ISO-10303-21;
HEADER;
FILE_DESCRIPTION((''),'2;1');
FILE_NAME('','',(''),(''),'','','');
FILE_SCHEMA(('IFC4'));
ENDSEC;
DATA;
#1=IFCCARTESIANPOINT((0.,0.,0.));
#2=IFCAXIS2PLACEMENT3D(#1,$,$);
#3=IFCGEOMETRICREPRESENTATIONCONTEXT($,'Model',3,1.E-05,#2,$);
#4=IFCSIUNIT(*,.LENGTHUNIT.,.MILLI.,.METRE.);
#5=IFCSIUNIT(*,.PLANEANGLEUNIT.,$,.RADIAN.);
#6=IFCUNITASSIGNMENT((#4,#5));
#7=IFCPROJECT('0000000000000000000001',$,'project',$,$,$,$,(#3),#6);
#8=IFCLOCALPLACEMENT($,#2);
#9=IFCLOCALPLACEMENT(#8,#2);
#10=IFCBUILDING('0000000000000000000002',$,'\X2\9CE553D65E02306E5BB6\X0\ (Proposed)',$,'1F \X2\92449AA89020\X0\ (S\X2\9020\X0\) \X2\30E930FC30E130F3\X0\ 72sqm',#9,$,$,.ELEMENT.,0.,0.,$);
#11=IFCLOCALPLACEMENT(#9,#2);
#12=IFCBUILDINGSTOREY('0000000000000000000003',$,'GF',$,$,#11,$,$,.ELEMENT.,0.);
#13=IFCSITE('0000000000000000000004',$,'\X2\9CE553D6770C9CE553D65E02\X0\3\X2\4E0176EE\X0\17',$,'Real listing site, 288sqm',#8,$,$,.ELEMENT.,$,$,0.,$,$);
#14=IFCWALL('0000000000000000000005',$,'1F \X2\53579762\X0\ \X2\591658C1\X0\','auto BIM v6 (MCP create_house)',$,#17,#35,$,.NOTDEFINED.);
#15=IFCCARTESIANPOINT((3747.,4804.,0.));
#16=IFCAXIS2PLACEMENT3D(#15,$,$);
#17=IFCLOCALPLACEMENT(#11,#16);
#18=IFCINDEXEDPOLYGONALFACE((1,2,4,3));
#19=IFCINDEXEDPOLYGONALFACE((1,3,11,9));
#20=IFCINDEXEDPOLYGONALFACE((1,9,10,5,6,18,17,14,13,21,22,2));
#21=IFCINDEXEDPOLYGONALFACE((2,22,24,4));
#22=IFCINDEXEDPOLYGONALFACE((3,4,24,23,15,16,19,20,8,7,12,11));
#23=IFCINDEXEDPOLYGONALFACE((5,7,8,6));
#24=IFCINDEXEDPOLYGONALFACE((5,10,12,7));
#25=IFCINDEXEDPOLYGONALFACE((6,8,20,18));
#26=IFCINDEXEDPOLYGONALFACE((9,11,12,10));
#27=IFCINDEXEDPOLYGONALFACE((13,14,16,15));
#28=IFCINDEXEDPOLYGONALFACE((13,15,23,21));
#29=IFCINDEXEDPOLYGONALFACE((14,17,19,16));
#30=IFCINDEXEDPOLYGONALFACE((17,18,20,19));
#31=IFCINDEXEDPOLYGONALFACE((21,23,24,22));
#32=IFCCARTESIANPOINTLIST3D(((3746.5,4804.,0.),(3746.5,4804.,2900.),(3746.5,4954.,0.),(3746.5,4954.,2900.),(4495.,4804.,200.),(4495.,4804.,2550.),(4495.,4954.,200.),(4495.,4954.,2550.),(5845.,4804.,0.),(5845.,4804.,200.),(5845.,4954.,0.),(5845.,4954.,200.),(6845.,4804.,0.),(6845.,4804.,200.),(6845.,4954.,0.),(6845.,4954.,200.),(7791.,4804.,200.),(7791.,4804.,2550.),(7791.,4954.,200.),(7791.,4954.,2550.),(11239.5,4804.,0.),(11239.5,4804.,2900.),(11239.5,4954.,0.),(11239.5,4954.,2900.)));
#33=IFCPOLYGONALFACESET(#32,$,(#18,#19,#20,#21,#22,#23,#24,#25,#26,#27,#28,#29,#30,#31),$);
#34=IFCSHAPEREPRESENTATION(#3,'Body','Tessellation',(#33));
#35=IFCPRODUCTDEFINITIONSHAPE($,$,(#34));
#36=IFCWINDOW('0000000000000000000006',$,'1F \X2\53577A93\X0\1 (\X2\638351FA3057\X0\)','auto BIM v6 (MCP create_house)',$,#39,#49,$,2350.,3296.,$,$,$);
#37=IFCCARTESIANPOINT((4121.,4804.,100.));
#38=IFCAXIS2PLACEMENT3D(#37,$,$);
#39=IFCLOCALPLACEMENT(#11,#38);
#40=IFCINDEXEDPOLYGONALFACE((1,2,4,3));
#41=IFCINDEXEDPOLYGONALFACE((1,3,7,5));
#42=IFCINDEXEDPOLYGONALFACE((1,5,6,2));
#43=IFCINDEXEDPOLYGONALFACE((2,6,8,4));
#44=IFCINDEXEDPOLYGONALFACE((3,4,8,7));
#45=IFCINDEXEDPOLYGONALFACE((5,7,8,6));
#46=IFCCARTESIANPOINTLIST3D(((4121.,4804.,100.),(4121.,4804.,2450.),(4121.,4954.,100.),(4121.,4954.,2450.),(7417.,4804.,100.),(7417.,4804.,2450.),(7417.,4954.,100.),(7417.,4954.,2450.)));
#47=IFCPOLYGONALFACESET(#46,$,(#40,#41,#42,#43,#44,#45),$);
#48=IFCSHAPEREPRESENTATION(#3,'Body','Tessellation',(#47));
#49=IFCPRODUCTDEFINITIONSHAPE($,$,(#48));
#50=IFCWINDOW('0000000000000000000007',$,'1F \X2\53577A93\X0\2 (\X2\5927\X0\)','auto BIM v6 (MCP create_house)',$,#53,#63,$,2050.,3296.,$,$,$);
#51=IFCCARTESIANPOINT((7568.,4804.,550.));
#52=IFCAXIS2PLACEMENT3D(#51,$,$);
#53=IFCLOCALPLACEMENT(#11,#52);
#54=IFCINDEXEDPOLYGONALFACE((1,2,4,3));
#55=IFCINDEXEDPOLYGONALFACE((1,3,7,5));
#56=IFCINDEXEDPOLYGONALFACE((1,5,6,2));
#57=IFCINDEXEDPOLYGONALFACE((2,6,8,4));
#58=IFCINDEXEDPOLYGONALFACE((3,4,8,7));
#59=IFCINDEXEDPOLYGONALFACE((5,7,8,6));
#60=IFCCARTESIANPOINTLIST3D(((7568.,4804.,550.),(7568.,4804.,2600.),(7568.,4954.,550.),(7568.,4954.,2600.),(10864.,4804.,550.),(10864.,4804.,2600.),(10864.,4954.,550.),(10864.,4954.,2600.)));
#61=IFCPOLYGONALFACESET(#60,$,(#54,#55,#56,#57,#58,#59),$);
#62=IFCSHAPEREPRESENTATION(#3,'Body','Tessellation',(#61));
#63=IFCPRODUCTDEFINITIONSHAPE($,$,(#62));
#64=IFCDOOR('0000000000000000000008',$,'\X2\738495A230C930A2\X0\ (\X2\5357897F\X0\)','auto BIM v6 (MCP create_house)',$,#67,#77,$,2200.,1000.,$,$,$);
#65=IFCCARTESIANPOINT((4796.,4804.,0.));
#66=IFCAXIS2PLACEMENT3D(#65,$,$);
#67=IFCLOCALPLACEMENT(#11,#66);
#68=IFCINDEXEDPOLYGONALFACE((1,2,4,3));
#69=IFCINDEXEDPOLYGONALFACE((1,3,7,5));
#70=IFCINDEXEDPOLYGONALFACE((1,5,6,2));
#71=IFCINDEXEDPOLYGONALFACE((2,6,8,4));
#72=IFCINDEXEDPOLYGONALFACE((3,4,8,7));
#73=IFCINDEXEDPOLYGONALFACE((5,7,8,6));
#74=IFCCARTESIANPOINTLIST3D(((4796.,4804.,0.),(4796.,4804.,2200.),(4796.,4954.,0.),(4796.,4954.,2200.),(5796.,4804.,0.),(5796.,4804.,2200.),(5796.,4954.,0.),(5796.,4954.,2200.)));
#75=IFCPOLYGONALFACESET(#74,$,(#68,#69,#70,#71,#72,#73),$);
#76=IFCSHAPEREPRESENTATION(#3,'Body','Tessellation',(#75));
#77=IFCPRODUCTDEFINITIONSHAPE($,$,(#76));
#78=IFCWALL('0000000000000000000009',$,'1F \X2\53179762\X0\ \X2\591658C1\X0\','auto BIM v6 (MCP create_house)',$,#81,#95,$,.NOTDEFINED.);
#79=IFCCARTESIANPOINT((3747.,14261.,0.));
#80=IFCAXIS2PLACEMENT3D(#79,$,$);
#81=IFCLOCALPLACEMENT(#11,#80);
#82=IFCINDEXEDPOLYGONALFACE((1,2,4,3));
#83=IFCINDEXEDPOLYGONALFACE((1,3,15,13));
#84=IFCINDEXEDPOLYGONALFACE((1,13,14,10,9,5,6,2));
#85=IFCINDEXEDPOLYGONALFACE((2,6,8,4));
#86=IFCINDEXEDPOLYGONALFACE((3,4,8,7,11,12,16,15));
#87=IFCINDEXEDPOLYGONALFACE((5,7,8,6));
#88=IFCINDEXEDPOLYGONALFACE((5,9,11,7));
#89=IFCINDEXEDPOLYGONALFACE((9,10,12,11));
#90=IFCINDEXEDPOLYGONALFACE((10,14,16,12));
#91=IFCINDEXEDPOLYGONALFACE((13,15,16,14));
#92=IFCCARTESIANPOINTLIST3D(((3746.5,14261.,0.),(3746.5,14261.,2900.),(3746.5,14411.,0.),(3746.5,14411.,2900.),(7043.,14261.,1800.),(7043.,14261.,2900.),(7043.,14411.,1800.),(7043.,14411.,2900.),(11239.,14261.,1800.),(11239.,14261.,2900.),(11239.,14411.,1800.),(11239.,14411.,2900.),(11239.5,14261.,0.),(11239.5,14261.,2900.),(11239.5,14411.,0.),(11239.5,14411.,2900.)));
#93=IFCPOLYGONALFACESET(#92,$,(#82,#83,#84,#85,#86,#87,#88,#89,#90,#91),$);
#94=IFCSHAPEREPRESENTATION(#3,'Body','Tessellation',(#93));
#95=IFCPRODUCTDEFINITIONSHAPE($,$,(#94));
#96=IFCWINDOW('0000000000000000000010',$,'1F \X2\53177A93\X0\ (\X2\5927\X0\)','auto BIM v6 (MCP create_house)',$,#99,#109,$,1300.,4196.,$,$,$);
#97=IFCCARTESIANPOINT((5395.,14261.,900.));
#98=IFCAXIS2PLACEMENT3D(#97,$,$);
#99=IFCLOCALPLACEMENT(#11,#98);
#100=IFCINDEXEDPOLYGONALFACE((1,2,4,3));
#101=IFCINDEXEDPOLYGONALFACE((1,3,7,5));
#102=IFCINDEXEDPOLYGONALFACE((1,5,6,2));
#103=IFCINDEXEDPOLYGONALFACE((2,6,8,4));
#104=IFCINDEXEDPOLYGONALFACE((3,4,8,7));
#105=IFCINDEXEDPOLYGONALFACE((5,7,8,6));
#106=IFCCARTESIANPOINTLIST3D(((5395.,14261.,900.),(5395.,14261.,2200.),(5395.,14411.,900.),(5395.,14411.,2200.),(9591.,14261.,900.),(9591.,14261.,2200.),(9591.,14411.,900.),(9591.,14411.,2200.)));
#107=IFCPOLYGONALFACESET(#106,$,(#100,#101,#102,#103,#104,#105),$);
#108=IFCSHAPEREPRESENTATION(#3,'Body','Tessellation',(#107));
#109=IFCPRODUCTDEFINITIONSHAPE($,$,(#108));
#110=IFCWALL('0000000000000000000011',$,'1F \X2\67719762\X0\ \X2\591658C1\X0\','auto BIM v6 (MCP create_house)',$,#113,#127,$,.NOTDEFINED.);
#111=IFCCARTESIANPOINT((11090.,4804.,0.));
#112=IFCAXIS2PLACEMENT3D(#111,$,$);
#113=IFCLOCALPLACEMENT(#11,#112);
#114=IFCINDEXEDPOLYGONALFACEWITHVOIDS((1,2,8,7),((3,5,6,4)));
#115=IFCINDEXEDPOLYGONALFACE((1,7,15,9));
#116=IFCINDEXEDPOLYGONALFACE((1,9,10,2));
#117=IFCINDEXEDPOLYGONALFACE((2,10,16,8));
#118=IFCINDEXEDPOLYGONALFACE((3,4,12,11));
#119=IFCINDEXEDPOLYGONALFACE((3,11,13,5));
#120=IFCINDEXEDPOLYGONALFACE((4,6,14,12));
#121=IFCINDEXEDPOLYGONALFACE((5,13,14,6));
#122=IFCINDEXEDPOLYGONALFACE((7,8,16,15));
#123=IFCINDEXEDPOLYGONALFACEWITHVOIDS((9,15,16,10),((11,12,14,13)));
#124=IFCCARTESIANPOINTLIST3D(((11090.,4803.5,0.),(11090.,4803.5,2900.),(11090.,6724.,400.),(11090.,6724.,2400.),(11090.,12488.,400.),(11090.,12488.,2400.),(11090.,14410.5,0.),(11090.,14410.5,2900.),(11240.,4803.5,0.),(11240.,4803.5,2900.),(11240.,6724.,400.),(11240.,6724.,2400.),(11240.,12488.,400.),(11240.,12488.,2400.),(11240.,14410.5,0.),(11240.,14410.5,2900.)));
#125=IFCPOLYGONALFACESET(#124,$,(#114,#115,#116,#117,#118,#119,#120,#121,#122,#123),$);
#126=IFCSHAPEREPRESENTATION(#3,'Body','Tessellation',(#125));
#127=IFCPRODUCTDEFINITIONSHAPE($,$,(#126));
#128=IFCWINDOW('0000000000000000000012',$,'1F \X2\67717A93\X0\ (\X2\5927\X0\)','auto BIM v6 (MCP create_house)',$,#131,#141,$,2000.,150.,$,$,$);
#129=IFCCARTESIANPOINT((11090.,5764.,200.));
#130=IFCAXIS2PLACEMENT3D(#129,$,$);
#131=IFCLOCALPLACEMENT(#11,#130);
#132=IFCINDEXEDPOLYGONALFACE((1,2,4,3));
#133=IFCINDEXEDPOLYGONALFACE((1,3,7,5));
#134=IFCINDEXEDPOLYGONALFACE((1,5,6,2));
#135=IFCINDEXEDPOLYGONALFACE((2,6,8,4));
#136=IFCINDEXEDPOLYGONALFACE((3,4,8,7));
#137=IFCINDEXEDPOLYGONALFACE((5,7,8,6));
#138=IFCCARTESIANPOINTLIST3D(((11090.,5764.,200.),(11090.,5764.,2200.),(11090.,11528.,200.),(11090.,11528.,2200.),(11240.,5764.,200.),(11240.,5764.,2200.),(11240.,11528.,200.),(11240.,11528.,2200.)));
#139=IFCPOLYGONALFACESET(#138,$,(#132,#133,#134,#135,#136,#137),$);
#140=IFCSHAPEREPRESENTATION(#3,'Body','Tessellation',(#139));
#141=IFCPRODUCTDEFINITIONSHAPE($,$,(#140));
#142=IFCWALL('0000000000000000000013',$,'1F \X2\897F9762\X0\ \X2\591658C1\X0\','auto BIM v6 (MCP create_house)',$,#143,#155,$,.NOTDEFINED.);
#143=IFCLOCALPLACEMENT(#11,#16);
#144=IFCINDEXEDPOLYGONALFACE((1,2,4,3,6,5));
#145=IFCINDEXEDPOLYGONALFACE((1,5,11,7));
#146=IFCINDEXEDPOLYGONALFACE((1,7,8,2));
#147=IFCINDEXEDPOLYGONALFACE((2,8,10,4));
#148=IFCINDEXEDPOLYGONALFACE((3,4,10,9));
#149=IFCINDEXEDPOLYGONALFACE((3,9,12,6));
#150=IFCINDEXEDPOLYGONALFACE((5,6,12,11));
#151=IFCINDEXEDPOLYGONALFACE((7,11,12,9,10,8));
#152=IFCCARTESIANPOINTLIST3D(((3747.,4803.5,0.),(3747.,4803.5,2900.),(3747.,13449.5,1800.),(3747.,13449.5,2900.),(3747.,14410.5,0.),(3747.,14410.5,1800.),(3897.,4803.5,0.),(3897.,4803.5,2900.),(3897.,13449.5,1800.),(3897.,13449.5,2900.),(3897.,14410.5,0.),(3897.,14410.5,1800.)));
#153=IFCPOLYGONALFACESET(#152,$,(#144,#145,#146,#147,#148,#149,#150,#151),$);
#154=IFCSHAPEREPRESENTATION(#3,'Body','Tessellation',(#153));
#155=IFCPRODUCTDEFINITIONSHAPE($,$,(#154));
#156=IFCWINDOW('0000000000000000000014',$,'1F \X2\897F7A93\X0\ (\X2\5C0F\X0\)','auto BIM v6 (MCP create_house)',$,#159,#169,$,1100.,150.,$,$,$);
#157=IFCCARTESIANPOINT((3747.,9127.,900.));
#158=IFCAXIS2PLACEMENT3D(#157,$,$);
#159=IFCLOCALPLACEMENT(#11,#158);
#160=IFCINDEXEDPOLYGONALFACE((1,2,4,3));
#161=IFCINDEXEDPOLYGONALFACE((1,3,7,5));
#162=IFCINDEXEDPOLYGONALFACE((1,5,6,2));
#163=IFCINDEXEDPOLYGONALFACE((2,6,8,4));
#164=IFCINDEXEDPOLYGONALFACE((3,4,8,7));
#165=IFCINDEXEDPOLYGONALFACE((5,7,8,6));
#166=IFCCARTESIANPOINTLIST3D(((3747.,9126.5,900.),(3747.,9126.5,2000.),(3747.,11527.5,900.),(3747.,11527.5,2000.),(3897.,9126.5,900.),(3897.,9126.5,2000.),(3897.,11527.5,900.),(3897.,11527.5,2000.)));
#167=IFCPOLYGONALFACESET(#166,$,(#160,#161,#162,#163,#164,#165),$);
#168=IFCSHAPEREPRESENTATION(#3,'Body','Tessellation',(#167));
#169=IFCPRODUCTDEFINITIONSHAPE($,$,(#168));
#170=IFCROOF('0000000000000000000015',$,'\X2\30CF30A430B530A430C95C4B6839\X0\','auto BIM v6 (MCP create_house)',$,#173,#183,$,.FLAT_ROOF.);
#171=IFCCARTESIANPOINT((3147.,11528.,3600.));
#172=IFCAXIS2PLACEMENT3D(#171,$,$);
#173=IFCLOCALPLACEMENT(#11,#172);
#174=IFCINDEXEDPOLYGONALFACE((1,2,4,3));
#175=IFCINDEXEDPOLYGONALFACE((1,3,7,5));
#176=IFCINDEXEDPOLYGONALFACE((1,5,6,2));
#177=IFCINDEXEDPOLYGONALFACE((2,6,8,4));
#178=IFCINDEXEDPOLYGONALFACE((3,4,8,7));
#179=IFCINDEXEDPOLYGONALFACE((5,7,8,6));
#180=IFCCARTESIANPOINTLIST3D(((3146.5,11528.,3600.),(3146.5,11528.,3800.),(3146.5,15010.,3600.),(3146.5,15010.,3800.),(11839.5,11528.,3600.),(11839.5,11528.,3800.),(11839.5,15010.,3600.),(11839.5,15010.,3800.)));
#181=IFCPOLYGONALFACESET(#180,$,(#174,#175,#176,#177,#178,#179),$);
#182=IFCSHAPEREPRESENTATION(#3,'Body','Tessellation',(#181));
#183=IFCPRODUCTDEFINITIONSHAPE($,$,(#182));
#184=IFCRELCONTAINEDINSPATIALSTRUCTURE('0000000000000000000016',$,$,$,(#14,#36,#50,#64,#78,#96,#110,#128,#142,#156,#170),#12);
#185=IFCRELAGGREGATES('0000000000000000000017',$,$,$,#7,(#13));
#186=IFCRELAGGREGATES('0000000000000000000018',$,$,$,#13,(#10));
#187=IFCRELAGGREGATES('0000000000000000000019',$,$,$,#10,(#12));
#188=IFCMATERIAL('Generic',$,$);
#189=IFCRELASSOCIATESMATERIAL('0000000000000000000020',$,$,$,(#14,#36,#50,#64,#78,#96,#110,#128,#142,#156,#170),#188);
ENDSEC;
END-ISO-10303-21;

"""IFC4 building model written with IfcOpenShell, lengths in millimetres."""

from ifc_helpers import new_model, si_unit, frame, frame_2d, origin, place, context, project, spatial, rectangle, extrude, material, element, fill, save


model = new_model("IFC4")

# Units and contexts
model_context = context("Model", 3, precision=1e-05, world=origin())
ifc_project = project(units=[si_unit("LENGTHUNIT", "METRE", prefix="MILLI"), si_unit("PLANEANGLEUNIT", "RADIAN")], contexts=[model_context])

# Site, building, storey
site_placement = place(None, origin())
site = spatial("IfcSite", under=ifc_project, at=site_placement, Name="鳥取県鳥取市3丁目17", ObjectType="Real listing site, 288sqm", CompositionType="ELEMENT", RefElevation=0.0)
building_placement = place(site_placement, origin())
building = spatial("IfcBuilding", under=site, at=building_placement, Name="鳥取市の家 (Proposed)", ObjectType="1F 鉄骨造 (S造) ラーメン 72sqm", CompositionType="ELEMENT", ElevationOfRefHeight=0.0, ElevationOfTerrain=0.0)
storey_placement = place(building_placement, origin())
storey = spatial("IfcBuildingStorey", under=building, at=storey_placement, Name="GF", CompositionType="ELEMENT", Elevation=0.0)

# Shared definitions
ifc_material = material(Name="Generic")

# Wall, openings, windows, door
wall_1_placement = place(storey_placement, frame((3747.0, 4804.0, 0.0)))
wall_1 = element("IfcWall", 1, at=wall_1_placement, inside=storey, material=ifc_material, Name="1F 南面 外壁", Description="auto BIM v6 (MCP create_house)", PredefinedType="NOTDEFINED", context=model_context, shape_type="SweptSolid", body=[
    extrude(rectangle(XDim=7493.0, YDim=150.0, at=frame_2d((3746.0, 75.0))), frame((3747.0, 4804.0, 0.0)), (0.0, 0.0, 1.0), 2900.0),
])
opening_1_placement = place(storey_placement, frame((4121.0, 4804.0, 100.0)))
opening_1 = element("IfcOpeningElement", 2, at=opening_1_placement, cuts=wall_1, PredefinedType="NOTDEFINED", context=model_context, shape_type="SweptSolid", body=[
    extrude(rectangle(XDim=3296.0, YDim=150.0, at=frame_2d((1648.0, 75.0))), frame((4121.0, 4804.0, 100.0)), (0.0, 0.0, 1.0), 2350.0),
])
opening_2_placement = place(storey_placement, frame((7568.0, 4804.0, 550.0)))
opening_2 = element("IfcOpeningElement", 3, at=opening_2_placement, cuts=wall_1, PredefinedType="NOTDEFINED", context=model_context, shape_type="SweptSolid", body=[
    extrude(rectangle(XDim=3296.0, YDim=150.0, at=frame_2d((1648.0, 75.0))), frame((7568.0, 4804.0, 550.0)), (0.0, 0.0, 1.0), 2050.0),
])
opening_3_placement = place(storey_placement, frame((4796.0, 4804.0, 0.0)))
opening_3 = element("IfcOpeningElement", 4, at=opening_3_placement, cuts=wall_1, PredefinedType="NOTDEFINED", context=model_context, shape_type="SweptSolid", body=[
    extrude(rectangle(XDim=1000.0, YDim=150.0, at=frame_2d((500.0, 75.0))), frame((4796.0, 4804.0, 0.0)), (0.0, 0.0, 1.0), 2200.0),
])
window_1_placement = place(storey_placement, frame((4121.0, 4804.0, 100.0)))
window_1 = element("IfcWindow", 5, at=window_1_placement, inside=storey, material=ifc_material, Name="1F 南窓1 (掃出し)", Description="auto BIM v6 (MCP create_house)", OverallHeight=2350.0, OverallWidth=3296.0, context=model_context, shape_type="SweptSolid", body=[
    extrude(rectangle(XDim=3296.0, YDim=150.0, at=frame_2d((1648.0, 75.0))), frame((4121.0, 4804.0, 100.0)), (0.0, 0.0, 1.0), 2350.0),
])
fill(opening_1, window_1)
window_2_placement = place(storey_placement, frame((7568.0, 4804.0, 550.0)))
window_2 = element("IfcWindow", 6, at=window_2_placement, inside=storey, material=ifc_material, Name="1F 南窓2 (大)", Description="auto BIM v6 (MCP create_house)", OverallHeight=2050.0, OverallWidth=3296.0, context=model_context, shape_type="SweptSolid", body=[
    extrude(rectangle(XDim=3296.0, YDim=150.0, at=frame_2d((1648.0, 75.0))), frame((7568.0, 4804.0, 550.0)), (0.0, 0.0, 1.0), 2050.0),
])
fill(opening_2, window_2)
door_placement = place(storey_placement, frame((4796.0, 4804.0, 0.0)))
door = element("IfcDoor", 7, at=door_placement, inside=storey, material=ifc_material, Name="玄関ドア (南西)", Description="auto BIM v6 (MCP create_house)", OverallHeight=2200.0, OverallWidth=1000.0, context=model_context, shape_type="SweptSolid", body=[
    extrude(rectangle(XDim=1000.0, YDim=150.0, at=frame_2d((500.0, 75.0))), frame((4796.0, 4804.0, 0.0)), (0.0, 0.0, 1.0), 2200.0),
])
fill(opening_3, door)

# Walls, openings, windows
wall_2_placement = place(storey_placement, frame((3747.0, 14261.0, 0.0)))
wall_2 = element("IfcWall", 8, at=wall_2_placement, inside=storey, material=ifc_material, Name="1F 北面 外壁", Description="auto BIM v6 (MCP create_house)", PredefinedType="NOTDEFINED", context=model_context, shape_type="SweptSolid", body=[
    extrude(rectangle(XDim=7493.0, YDim=150.0, at=frame_2d((3746.0, 75.0))), frame((3747.0, 14261.0, 0.0)), (0.0, 0.0, 1.0), 2900.0),
])
opening_4_placement = place(storey_placement, frame((5395.0, 14261.0, 900.0)))
opening_4 = element("IfcOpeningElement", 9, at=opening_4_placement, cuts=wall_2, PredefinedType="NOTDEFINED", context=model_context, shape_type="SweptSolid", body=[
    extrude(rectangle(XDim=4196.0, YDim=150.0, at=frame_2d((2098.0, 75.0))), frame((5395.0, 14261.0, 900.0)), (0.0, 0.0, 1.0), 1300.0),
])
window_3_placement = place(storey_placement, frame((5395.0, 14261.0, 900.0)))
window_3 = element("IfcWindow", 10, at=window_3_placement, inside=storey, material=ifc_material, Name="1F 北窓 (大)", Description="auto BIM v6 (MCP create_house)", OverallHeight=1300.0, OverallWidth=4196.0, context=model_context, shape_type="SweptSolid", body=[
    extrude(rectangle(XDim=4196.0, YDim=150.0, at=frame_2d((2098.0, 75.0))), frame((5395.0, 14261.0, 900.0)), (0.0, 0.0, 1.0), 1300.0),
])
fill(opening_4, window_3)
wall_3_placement = place(storey_placement, frame((11090.0, 4804.0, 0.0)))
wall_3 = element("IfcWall", 11, at=wall_3_placement, inside=storey, material=ifc_material, Name="1F 東面 外壁", Description="auto BIM v6 (MCP create_house)", PredefinedType="NOTDEFINED", context=model_context, shape_type="SweptSolid", body=[
    extrude(rectangle(XDim=150.0, YDim=9607.0, at=frame_2d((75.0, 4803.0))), frame((11090.0, 4804.0, 0.0)), (0.0, 0.0, 1.0), 2900.0),
])
opening_5_placement = place(storey_placement, frame((11090.0, 5764.0, 200.0)))
opening_5 = element("IfcOpeningElement", 12, at=opening_5_placement, cuts=wall_3, PredefinedType="NOTDEFINED", context=model_context, shape_type="SweptSolid", body=[
    extrude(rectangle(XDim=150.0, YDim=5764.0, at=frame_2d((75.0, 2882.0))), frame((11090.0, 5764.0, 200.0)), (0.0, 0.0, 1.0), 2000.0),
])
window_4_placement = place(storey_placement, frame((11090.0, 5764.0, 200.0)))
window_4 = element("IfcWindow", 13, at=window_4_placement, inside=storey, material=ifc_material, Name="1F 東窓 (大)", Description="auto BIM v6 (MCP create_house)", OverallHeight=2000.0, OverallWidth=150.0, context=model_context, shape_type="SweptSolid", body=[
    extrude(rectangle(XDim=150.0, YDim=5764.0, at=frame_2d((75.0, 2882.0))), frame((11090.0, 5764.0, 200.0)), (0.0, 0.0, 1.0), 2000.0),
])
fill(opening_5, window_4)
wall_4_placement = place(storey_placement, frame((3747.0, 4804.0, 0.0)))
wall_4 = element("IfcWall", 14, at=wall_4_placement, inside=storey, material=ifc_material, Name="1F 西面 外壁", Description="auto BIM v6 (MCP create_house)", PredefinedType="NOTDEFINED", context=model_context, shape_type="SweptSolid", body=[
    extrude(rectangle(XDim=150.0, YDim=9607.0, at=frame_2d((75.0, 4803.0))), frame((3747.0, 4804.0, 0.0)), (0.0, 0.0, 1.0), 2900.0),
])
opening_6_placement = place(storey_placement, frame((3747.0, 9127.0, 900.0)))
opening_6 = element("IfcOpeningElement", 15, at=opening_6_placement, cuts=wall_4, PredefinedType="NOTDEFINED", context=model_context, shape_type="SweptSolid", body=[
    extrude(rectangle(XDim=150.0, YDim=2401.0, at=frame_2d((75.0, 1200.0))), frame((3747.0, 9127.0, 900.0)), (0.0, 0.0, 1.0), 1100.0),
])
window_5_placement = place(storey_placement, frame((3747.0, 9127.0, 900.0)))
window_5 = element("IfcWindow", 16, at=window_5_placement, inside=storey, material=ifc_material, Name="1F 西窓 (小)", Description="auto BIM v6 (MCP create_house)", OverallHeight=1100.0, OverallWidth=150.0, context=model_context, shape_type="SweptSolid", body=[
    extrude(rectangle(XDim=150.0, YDim=2401.0, at=frame_2d((75.0, 1200.0))), frame((3747.0, 9127.0, 900.0)), (0.0, 0.0, 1.0), 1100.0),
])
fill(opening_6, window_5)

# Roof
roof_1_placement = place(storey_placement, frame((3147.0, 11528.0, 3600.0)))
element("IfcRoof", 17, at=roof_1_placement, inside=storey, material=ifc_material, Name="ハイサイド屋根", Description="auto BIM v6 (MCP create_house)", PredefinedType="FLAT_ROOF", context=model_context, shape_type="SweptSolid", body=[
    extrude(rectangle(XDim=8693.0, YDim=3482.0, at=frame_2d((4346.0, 1741.0))), frame((3147.0, 11528.0, 3600.0)), (0.0, 0.0, 1.0), 200.0),
])

save(model, "model.ifc")
